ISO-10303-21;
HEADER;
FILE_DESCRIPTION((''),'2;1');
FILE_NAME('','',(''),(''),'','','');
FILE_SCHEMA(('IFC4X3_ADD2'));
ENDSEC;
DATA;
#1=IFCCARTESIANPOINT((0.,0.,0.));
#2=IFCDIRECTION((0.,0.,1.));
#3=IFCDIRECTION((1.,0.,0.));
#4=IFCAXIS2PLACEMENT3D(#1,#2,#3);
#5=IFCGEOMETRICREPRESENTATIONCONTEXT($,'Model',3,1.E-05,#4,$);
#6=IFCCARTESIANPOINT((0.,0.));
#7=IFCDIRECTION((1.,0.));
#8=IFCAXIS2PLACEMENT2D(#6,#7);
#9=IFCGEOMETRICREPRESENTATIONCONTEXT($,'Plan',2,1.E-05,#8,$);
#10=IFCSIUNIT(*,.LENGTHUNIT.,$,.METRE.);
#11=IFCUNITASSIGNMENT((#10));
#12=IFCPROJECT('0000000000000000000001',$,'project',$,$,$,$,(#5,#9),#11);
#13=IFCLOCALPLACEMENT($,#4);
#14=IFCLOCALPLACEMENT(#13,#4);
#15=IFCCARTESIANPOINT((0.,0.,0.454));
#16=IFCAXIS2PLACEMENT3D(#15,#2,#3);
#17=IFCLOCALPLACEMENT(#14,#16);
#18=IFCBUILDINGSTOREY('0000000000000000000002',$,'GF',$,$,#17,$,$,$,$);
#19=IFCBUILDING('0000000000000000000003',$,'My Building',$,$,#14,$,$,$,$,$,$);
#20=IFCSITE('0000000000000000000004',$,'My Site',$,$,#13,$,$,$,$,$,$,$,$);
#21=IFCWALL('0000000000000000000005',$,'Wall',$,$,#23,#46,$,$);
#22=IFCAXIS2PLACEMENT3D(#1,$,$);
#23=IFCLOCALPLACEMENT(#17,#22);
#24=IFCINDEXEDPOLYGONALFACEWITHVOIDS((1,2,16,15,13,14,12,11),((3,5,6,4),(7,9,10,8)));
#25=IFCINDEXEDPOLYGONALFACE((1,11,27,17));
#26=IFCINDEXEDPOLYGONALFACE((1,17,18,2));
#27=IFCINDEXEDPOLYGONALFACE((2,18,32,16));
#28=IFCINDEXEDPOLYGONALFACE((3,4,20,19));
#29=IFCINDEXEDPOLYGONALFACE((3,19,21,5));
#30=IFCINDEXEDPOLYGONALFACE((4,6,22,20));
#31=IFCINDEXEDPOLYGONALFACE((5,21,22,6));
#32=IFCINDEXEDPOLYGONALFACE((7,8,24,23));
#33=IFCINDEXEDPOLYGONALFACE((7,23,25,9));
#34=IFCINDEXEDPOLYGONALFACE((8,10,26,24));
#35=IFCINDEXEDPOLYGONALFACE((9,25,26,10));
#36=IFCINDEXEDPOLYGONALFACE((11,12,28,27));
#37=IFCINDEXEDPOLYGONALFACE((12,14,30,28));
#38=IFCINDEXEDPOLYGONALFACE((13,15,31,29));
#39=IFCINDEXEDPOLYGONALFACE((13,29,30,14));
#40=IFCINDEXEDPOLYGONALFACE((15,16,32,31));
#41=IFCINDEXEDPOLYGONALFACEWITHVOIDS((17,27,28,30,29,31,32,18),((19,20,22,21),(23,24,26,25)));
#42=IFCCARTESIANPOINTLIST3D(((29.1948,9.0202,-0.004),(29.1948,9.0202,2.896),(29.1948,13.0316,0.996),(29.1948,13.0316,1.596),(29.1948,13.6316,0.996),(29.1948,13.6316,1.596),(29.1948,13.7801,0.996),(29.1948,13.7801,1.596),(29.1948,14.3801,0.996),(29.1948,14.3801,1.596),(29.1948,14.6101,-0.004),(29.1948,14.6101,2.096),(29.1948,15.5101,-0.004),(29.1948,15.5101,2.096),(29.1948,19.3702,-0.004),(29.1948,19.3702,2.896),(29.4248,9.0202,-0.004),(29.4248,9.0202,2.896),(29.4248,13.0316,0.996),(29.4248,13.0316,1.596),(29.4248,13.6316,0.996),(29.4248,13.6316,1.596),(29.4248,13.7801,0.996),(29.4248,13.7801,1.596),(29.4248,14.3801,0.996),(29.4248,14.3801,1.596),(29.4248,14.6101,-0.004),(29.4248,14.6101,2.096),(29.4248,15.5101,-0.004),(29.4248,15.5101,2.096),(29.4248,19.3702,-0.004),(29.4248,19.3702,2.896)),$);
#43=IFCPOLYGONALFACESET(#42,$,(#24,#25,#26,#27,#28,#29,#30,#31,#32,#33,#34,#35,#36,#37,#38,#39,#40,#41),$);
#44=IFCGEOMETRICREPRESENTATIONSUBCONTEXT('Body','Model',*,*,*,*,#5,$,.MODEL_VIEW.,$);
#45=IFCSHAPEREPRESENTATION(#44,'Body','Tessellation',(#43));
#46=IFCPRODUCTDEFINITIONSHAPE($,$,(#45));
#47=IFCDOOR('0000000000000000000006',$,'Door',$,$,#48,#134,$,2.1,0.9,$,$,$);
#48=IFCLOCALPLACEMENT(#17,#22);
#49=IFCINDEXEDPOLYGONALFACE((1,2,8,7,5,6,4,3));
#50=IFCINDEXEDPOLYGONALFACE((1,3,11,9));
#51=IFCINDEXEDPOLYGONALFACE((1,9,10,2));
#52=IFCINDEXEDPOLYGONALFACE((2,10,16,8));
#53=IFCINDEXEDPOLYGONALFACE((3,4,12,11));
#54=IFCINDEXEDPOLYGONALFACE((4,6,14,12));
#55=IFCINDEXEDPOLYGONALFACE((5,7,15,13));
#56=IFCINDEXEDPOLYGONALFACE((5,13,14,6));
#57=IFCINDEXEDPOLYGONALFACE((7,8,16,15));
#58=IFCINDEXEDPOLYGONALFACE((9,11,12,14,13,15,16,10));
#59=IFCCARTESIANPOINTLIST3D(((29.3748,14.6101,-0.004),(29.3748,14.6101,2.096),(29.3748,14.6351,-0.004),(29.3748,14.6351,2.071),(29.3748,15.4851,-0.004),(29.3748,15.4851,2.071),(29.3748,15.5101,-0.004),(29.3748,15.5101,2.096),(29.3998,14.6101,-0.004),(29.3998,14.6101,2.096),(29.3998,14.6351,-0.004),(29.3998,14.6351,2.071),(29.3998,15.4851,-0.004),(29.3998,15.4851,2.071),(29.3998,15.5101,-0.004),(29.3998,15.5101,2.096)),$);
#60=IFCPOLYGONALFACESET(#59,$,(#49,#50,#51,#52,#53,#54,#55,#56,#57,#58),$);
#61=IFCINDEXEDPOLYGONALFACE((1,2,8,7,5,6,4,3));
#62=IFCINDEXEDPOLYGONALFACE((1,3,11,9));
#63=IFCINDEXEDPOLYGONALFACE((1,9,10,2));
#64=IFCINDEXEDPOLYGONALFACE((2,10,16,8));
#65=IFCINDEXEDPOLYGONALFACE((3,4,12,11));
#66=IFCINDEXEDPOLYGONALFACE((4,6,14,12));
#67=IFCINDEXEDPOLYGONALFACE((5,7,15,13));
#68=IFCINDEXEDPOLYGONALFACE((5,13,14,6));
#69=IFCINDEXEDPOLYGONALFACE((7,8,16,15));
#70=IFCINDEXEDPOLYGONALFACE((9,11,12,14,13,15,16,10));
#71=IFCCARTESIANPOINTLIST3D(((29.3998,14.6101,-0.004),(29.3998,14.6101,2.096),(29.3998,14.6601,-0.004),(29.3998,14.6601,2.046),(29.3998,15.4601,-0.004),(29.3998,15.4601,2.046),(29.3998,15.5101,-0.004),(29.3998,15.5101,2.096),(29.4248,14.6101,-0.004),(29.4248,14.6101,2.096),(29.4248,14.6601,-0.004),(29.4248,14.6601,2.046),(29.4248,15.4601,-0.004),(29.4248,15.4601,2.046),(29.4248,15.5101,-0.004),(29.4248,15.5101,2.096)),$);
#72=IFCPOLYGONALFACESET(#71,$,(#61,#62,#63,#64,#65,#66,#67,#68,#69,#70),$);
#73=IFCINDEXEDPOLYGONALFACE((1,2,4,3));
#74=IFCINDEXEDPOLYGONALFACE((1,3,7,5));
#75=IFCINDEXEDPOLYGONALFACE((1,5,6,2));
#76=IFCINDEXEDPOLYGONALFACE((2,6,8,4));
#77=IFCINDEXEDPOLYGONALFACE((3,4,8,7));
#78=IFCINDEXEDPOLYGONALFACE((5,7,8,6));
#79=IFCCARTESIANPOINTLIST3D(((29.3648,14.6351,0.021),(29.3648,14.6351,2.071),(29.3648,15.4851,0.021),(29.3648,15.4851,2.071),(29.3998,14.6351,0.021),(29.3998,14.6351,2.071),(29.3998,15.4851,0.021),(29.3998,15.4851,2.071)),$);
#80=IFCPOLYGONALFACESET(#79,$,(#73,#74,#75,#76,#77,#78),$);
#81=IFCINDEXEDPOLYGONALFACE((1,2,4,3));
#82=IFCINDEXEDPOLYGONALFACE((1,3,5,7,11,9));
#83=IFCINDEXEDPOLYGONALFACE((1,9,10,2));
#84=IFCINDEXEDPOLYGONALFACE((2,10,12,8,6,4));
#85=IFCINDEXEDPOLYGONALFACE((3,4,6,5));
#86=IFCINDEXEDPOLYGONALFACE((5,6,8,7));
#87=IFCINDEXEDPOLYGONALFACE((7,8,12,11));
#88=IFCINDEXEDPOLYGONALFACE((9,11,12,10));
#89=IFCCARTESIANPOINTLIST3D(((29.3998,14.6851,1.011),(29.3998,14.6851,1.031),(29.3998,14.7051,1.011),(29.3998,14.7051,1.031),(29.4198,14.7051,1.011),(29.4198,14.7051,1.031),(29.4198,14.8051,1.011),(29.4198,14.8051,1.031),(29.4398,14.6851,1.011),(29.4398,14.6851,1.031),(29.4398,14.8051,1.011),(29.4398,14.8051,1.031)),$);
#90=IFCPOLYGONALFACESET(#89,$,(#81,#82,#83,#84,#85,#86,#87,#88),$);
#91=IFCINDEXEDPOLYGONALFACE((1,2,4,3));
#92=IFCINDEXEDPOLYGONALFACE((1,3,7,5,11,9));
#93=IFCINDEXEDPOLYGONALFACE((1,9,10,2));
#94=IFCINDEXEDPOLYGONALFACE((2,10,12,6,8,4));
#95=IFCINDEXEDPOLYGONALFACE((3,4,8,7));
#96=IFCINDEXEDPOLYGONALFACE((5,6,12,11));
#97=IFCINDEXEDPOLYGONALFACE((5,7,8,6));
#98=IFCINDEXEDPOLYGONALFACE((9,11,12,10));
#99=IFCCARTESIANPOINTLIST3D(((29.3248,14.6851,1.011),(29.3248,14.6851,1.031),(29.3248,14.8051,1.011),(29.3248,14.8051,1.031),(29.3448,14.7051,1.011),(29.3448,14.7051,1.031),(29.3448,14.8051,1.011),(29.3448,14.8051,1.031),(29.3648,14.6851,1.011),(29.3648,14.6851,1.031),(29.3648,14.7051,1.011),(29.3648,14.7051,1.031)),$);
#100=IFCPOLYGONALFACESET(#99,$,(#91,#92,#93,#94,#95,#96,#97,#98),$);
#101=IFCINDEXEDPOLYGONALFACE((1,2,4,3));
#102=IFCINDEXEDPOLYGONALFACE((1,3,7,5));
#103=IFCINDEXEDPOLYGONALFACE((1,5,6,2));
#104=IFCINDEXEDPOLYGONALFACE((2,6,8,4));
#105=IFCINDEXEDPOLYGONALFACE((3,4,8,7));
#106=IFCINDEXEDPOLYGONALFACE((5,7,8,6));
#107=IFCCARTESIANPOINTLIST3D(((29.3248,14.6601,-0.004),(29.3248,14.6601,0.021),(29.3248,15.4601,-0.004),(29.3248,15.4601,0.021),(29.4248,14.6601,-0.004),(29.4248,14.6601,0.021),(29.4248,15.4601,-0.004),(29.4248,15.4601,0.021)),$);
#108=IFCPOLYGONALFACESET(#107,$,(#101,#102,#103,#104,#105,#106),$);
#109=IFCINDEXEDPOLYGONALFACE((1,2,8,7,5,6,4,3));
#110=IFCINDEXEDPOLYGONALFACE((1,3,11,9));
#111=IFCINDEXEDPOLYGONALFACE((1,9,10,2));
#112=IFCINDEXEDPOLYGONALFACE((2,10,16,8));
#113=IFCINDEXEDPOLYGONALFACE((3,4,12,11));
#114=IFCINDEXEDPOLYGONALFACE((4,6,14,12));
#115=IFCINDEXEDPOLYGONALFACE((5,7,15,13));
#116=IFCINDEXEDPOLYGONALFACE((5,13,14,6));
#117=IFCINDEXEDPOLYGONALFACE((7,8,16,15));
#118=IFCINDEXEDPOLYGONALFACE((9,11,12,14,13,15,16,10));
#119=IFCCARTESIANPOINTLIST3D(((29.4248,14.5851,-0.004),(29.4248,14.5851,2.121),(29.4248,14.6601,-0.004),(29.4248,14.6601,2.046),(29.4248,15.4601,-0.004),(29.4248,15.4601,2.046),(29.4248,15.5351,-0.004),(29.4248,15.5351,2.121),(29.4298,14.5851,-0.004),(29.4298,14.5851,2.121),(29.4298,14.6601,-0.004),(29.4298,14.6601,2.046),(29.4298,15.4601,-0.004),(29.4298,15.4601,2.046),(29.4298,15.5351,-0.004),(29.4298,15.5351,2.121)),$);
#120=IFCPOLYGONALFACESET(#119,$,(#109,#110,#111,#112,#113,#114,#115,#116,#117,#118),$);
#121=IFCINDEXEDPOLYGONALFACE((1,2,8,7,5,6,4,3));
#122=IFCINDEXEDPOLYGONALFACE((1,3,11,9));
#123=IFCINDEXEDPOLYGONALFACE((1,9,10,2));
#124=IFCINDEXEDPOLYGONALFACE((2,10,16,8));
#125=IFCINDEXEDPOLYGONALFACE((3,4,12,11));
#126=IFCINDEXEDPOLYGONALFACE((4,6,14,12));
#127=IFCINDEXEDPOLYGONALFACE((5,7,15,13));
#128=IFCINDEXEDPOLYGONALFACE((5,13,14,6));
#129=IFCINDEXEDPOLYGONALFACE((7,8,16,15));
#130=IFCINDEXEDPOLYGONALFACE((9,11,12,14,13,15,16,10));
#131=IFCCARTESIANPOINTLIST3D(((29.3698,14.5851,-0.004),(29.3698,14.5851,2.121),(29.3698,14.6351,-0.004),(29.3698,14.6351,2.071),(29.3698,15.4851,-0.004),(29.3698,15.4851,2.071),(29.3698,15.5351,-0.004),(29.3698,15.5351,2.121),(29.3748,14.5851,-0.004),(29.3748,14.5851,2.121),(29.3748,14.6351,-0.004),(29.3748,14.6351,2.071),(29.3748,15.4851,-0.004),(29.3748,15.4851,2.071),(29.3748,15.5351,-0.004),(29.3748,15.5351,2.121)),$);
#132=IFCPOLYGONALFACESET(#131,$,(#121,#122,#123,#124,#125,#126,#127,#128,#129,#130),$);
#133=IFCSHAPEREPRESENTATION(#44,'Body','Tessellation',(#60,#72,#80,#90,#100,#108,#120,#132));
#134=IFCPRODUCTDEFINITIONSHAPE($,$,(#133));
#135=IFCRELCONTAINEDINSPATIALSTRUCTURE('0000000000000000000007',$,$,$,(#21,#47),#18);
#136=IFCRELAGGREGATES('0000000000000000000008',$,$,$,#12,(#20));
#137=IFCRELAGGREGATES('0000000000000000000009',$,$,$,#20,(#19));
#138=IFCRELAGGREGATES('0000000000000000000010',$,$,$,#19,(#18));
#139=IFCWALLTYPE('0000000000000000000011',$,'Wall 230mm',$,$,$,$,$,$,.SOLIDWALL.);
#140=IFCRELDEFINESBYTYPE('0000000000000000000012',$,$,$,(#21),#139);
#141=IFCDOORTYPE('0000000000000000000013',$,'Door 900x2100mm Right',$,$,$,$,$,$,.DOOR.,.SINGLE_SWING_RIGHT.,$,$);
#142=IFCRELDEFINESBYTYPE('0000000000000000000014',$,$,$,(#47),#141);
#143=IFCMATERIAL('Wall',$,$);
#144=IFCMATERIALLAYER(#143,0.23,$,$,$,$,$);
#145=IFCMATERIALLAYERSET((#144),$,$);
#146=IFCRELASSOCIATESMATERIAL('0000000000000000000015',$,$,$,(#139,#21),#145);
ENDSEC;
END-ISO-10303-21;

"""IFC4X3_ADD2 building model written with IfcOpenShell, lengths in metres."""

from ifc_helpers import new_model, entity, si_unit, frame, origin_with_axes, origin_2d_with_axis, place, context, subcontext, project, spatial, line, indexed_curve, outline, extrude, shape, source, transform, mapped, material, layer, layer_set, layer_usage, type_object, type_shapes, element, fill, save


model = new_model("IFC4X3_ADD2")

# Units and contexts
model_context = context("Model", 3, precision=1e-05, world=origin_with_axes())
plan_context = context("Plan", 2, precision=1e-05, world=origin_2d_with_axis())
body_context_1 = subcontext(model_context, "Body", "Model", "MODEL_VIEW")
body_context_2 = subcontext(plan_context, "Body", "Plan", "PLAN_VIEW")
ifc_project = project(units=[si_unit("LENGTHUNIT", "METRE")], contexts=[model_context, plan_context])

# Site, building, storey
site_placement = place(None, origin_with_axes())
site = spatial("IfcSite", under=ifc_project, at=site_placement, Name="My Site")
building_placement = place(site_placement, origin_with_axes())
building = spatial("IfcBuilding", under=site, at=building_placement, Name="My Building")
storey_placement = place(building_placement, frame((0.0, 0.0, 0.454), z_axis=(0.0, 0.0, 1.0), x_axis=(1.0, 0.0, 0.0)))
storey = spatial("IfcBuildingStorey", under=building, at=storey_placement, Name="GF")

# Wall, openings, door
ifc_material_1 = material(Name="Wall")
ifc_layer = layer(ifc_material_1, 0.23)
ifc_layer_set = layer_set([ifc_layer])
ifc_layer_usage_1 = layer_usage(ifc_layer_set, "AXIS2", "POSITIVE", 0.0)
wall_type = type_object("IfcWallType", Name="Wall 230mm", PredefinedType="SOLIDWALL", material=ifc_layer_set)
wall_1_placement = place(storey_placement, frame((29.4248, 9.0202, -0.004), z_axis=(0.0, 0.0, 1.0), x_axis=(0.000001, 1.0, 0.0)))
wall_1 = element("IfcWall", 1, at=wall_1_placement, inside=storey, type_object=wall_type, material=ifc_layer_usage_1, Name="Wall", context=body_context_1, shape_type="SweptSolid", body=[
    extrude(outline(indexed_curve([(0.0, 0.0), (0.0, 0.23), (10.35, 0.23), (10.35, 0.0), (0.0, 0.0)], self_intersect=False)), origin_with_axes(), (0.0, 0.0, 1.0), 2.9),
])
shared_shape_1 = source(origin_with_axes(), body_context_1, "Body", "SweptSolid", [
    extrude(outline(indexed_curve([(0.0, 0.0), (0.9, 0.0), (0.9, 2.1), (0.0, 2.1)], segments=[line(1, 2, 3, 4, 1)])), frame((0.0, -0.6, 0.0), z_axis=(0.0, -1.0, 0.0), x_axis=(1.0, 0.0, 0.0)), (0.0, 0.0, -1.0), 1.2),
])
opening_1_placement = place(wall_1_placement, frame((5.5899, 0.0, 0.0), z_axis=(0.0, 0.0, 1.0), x_axis=(1.0, 0.0, 0.0)))
opening_1 = element("IfcOpeningElement", 2, at=opening_1_placement, cuts=wall_1, PredefinedType="OPENING", context=body_context_1, shape_type="MappedRepresentation", body=[
    mapped(shared_shape_1, transform((0.0, 0.0, 0.0), x_axis=(1.0, 0.0, 0.0), y_axis=(0.0, 1.0, 0.0), z_axis=(0.0, 0.0, 1.0), scale=1.0)),
])
shared_shape_2 = source(origin_with_axes(), body_context_1, "Body", "SweptSolid", [
    extrude(outline(indexed_curve([(0.0, 0.0), (0.6, 0.0), (0.6, 0.6), (0.0, 0.6)], segments=[line(1, 2, 3, 4, 1)])), frame((-0.3, -0.6, 0.0), z_axis=(0.0, -1.0, 0.0), x_axis=(1.0, 0.0, 0.0)), (0.0, 0.0, -1.0), 1.2),
])
opening_2_placement = place(wall_1_placement, frame((5.0599, 0.0, 1.0), z_axis=(0.0, 0.0, 1.0), x_axis=(1.0, 0.0, 0.0)))
element("IfcOpeningElement", 3, at=opening_2_placement, cuts=wall_1, PredefinedType="OPENING", context=body_context_1, shape_type="MappedRepresentation", body=[
    mapped(shared_shape_2, transform((0.0, 0.0, 0.0), x_axis=(1.0, 0.0, 0.0), y_axis=(0.0, 1.0, 0.0), z_axis=(0.0, 0.0, 1.0), scale=1.0)),
])
opening_3_placement = place(wall_1_placement, frame((4.3114, 0.0, 1.0), z_axis=(0.0, 0.0, 1.0), x_axis=(1.0, 0.0, 0.0)))
element("IfcOpeningElement", 4, at=opening_3_placement, cuts=wall_1, PredefinedType="OPENING", context=body_context_1, shape_type="MappedRepresentation", body=[
    mapped(shared_shape_2, transform((0.0, 0.0, 0.0), x_axis=(1.0, 0.0, 0.0), y_axis=(0.0, 1.0, 0.0), z_axis=(0.0, 0.0, 1.0), scale=1.0)),
])
door_type_1 = type_object("IfcDoorType", Name="Door 900x2100mm Right", OperationType="SINGLE_SWING_RIGHT", PredefinedType="DOOR")
shared_shape_3 = source(origin_with_axes(), body_context_1, "Body", "SweptSolid", [
    extrude(outline(indexed_curve([(0.0, 0.0), (0.0, 2.1), (0.9, 2.1), (0.9, 0.0), (0.875, 0.0), (0.875, 2.075), (0.025, 2.075), (0.025, 0.0)], segments=[line(1, 2, 3, 4, 5, 6, 7, 8, 1)])), frame((0.0, 0.025, 0.0), z_axis=(0.0, -1.0, 0.0), x_axis=(1.0, 0.0, 0.0)), (0.0, 0.0, -1.0), 0.025),
    extrude(outline(indexed_curve([(0.0, 0.0), (0.0, 2.1), (0.9, 2.1), (0.9, 0.0), (0.85, 0.0), (0.85, 2.05), (0.05, 2.05), (0.05, 0.0)], segments=[line(1, 2, 3, 4, 5, 6, 7, 8, 1)])), frame((0.0, 0.0, 0.0), z_axis=(0.0, -1.0, 0.0), x_axis=(1.0, 0.0, 0.0)), (0.0, 0.0, -1.0), 0.025),
    extrude(outline(indexed_curve([(0.0, 0.0), (0.85, 0.0), (0.85, 0.035), (0.0, 0.035)], segments=[line(1, 2, 3, 4, 1)])), frame((0.025, 0.025, 0.025), z_axis=(0.0, 0.0, 1.0), x_axis=(1.0, 0.0, 0.0)), (0.0, 0.0, 1.0), 2.05),
    extrude(outline(indexed_curve([(0.0, 0.0), (0.0, -0.04), (0.12, -0.04), (0.12, -0.02), (0.02, -0.02), (0.02, 0.0)], segments=[line(1, 2, 3, 4, 5, 6, 1)])), frame((0.075, 0.025, 1.015), z_axis=(0.0, 0.0, 1.0), x_axis=(1.0, 0.0, 0.0)), (0.0, 0.0, 1.0), 0.02),
    extrude(outline(indexed_curve([(0.0, 0.0), (0.0, 0.04), (0.12, 0.04), (0.12, 0.02), (0.02, 0.02), (0.02, 0.0)], segments=[line(1, 2, 3, 4, 5, 6, 1)])), frame((0.075, 0.06, 1.015), z_axis=(0.0, 0.0, 1.0), x_axis=(1.0, 0.0, 0.0)), (0.0, 0.0, 1.0), 0.02),
    extrude(outline(indexed_curve([(0.0, 0.0), (0.8, 0.0), (0.8, 0.1), (0.0, 0.1)], segments=[line(1, 2, 3, 4, 1)])), frame((0.05, 0.0, 0.0), z_axis=(0.0, 0.0, 1.0), x_axis=(1.0, 0.0, 0.0)), (0.0, 0.0, 1.0), 0.025),
    extrude(outline(indexed_curve([(0.0, 0.0), (0.0, 2.125), (0.95, 2.125), (0.95, 0.0), (0.875, 0.0), (0.875, 2.05), (0.075, 2.05), (0.075, 0.0)], segments=[line(1, 2, 3, 4, 5, 6, 7, 8, 1)])), frame((-0.025, -0.005, 0.0), z_axis=(0.0, -1.0, 0.0), x_axis=(1.0, 0.0, 0.0)), (0.0, 0.0, -1.0), 0.005),
    extrude(outline(indexed_curve([(0.0, 0.0), (0.0, 2.125), (0.95, 2.125), (0.95, 0.0), (0.9, 0.0), (0.9, 2.075), (0.05, 2.075), (0.05, 0.0)], segments=[line(1, 2, 3, 4, 5, 6, 7, 8, 1)])), frame((-0.025, 0.05, 0.0), z_axis=(0.0, -1.0, 0.0), x_axis=(1.0, 0.0, 0.0)), (0.0, 0.0, -1.0), 0.005),
])
shared_shape_4 = source(origin_with_axes(), body_context_2, "Body", "Curve2D", [
    entity("IfcIndexedPolyCurve", entity("IfcCartesianPointList2D", [[0.0, 0.0], [0.0, 0.05], [0.025, 0.05], [0.025, 0.025], [0.05, 0.025], [0.05, 0.0]]), [entity("IfcLineIndex", [1, 2, 3, 4, 5, 6, 1])]),
    entity("IfcIndexedPolyCurve", entity("IfcCartesianPointList2D", [[0.9, 0.0], [0.9, 0.05], [0.875, 0.05], [0.875, 0.025], [0.85, 0.025], [0.85, 0.0]]), [entity("IfcLineIndex", [1, 2, 3, 4, 5, 6, 1])]),
    entity("IfcTrimmedCurve", entity("IfcEllipse", entity("IfcAxis2Placement2D", entity("IfcCartesianPoint", [0.84, 0.05]), entity("IfcDirection", [1.0, 0.0])), 0.815, 0.85), [entity("IfcCartesianPoint", [0.84, 0.9])], [entity("IfcCartesianPoint", [0.025, 0.05])], True, "CARTESIAN"),
    entity("IfcIndexedPolyCurve", entity("IfcCartesianPointList2D", [[0.875, 0.05], [0.84, 0.05], [0.84, 0.9], [0.875, 0.9]]), [entity("IfcLineIndex", [1, 2, 3, 4, 1])]),
])
type_shapes(door_type_1, [shared_shape_3, shared_shape_4])
door_1_placement = place(opening_1_placement, frame((0.0, 0.0, 0.0), z_axis=(0.0, 0.0, 1.0), x_axis=(1.0, 0.0, 0.0)))
door_1 = element("IfcDoor", 5, at=door_1_placement, inside=storey, type_object=door_type_1, Name="Door", OverallHeight=2.1, OverallWidth=0.9, shapes=[
    shape(body_context_1, "Body", "MappedRepresentation", [mapped(shared_shape_3, transform((0.0, 0.0, 0.0), x_axis=(1.0, 0.0, 0.0), y_axis=(0.0, 1.0, 0.0), z_axis=(0.0, 0.0, 1.0), scale=1.0))]),
    shape(body_context_2, "Body", "MappedRepresentation", [mapped(shared_shape_4, transform((0.0, 0.0, 0.0), x_axis=(1.0, 0.0, 0.0), y_axis=(0.0, 1.0, 0.0), z_axis=(0.0, 0.0, 1.0), scale=1.0))]),
])
fill(opening_1, door_1)

save(model, "model.ifc")
